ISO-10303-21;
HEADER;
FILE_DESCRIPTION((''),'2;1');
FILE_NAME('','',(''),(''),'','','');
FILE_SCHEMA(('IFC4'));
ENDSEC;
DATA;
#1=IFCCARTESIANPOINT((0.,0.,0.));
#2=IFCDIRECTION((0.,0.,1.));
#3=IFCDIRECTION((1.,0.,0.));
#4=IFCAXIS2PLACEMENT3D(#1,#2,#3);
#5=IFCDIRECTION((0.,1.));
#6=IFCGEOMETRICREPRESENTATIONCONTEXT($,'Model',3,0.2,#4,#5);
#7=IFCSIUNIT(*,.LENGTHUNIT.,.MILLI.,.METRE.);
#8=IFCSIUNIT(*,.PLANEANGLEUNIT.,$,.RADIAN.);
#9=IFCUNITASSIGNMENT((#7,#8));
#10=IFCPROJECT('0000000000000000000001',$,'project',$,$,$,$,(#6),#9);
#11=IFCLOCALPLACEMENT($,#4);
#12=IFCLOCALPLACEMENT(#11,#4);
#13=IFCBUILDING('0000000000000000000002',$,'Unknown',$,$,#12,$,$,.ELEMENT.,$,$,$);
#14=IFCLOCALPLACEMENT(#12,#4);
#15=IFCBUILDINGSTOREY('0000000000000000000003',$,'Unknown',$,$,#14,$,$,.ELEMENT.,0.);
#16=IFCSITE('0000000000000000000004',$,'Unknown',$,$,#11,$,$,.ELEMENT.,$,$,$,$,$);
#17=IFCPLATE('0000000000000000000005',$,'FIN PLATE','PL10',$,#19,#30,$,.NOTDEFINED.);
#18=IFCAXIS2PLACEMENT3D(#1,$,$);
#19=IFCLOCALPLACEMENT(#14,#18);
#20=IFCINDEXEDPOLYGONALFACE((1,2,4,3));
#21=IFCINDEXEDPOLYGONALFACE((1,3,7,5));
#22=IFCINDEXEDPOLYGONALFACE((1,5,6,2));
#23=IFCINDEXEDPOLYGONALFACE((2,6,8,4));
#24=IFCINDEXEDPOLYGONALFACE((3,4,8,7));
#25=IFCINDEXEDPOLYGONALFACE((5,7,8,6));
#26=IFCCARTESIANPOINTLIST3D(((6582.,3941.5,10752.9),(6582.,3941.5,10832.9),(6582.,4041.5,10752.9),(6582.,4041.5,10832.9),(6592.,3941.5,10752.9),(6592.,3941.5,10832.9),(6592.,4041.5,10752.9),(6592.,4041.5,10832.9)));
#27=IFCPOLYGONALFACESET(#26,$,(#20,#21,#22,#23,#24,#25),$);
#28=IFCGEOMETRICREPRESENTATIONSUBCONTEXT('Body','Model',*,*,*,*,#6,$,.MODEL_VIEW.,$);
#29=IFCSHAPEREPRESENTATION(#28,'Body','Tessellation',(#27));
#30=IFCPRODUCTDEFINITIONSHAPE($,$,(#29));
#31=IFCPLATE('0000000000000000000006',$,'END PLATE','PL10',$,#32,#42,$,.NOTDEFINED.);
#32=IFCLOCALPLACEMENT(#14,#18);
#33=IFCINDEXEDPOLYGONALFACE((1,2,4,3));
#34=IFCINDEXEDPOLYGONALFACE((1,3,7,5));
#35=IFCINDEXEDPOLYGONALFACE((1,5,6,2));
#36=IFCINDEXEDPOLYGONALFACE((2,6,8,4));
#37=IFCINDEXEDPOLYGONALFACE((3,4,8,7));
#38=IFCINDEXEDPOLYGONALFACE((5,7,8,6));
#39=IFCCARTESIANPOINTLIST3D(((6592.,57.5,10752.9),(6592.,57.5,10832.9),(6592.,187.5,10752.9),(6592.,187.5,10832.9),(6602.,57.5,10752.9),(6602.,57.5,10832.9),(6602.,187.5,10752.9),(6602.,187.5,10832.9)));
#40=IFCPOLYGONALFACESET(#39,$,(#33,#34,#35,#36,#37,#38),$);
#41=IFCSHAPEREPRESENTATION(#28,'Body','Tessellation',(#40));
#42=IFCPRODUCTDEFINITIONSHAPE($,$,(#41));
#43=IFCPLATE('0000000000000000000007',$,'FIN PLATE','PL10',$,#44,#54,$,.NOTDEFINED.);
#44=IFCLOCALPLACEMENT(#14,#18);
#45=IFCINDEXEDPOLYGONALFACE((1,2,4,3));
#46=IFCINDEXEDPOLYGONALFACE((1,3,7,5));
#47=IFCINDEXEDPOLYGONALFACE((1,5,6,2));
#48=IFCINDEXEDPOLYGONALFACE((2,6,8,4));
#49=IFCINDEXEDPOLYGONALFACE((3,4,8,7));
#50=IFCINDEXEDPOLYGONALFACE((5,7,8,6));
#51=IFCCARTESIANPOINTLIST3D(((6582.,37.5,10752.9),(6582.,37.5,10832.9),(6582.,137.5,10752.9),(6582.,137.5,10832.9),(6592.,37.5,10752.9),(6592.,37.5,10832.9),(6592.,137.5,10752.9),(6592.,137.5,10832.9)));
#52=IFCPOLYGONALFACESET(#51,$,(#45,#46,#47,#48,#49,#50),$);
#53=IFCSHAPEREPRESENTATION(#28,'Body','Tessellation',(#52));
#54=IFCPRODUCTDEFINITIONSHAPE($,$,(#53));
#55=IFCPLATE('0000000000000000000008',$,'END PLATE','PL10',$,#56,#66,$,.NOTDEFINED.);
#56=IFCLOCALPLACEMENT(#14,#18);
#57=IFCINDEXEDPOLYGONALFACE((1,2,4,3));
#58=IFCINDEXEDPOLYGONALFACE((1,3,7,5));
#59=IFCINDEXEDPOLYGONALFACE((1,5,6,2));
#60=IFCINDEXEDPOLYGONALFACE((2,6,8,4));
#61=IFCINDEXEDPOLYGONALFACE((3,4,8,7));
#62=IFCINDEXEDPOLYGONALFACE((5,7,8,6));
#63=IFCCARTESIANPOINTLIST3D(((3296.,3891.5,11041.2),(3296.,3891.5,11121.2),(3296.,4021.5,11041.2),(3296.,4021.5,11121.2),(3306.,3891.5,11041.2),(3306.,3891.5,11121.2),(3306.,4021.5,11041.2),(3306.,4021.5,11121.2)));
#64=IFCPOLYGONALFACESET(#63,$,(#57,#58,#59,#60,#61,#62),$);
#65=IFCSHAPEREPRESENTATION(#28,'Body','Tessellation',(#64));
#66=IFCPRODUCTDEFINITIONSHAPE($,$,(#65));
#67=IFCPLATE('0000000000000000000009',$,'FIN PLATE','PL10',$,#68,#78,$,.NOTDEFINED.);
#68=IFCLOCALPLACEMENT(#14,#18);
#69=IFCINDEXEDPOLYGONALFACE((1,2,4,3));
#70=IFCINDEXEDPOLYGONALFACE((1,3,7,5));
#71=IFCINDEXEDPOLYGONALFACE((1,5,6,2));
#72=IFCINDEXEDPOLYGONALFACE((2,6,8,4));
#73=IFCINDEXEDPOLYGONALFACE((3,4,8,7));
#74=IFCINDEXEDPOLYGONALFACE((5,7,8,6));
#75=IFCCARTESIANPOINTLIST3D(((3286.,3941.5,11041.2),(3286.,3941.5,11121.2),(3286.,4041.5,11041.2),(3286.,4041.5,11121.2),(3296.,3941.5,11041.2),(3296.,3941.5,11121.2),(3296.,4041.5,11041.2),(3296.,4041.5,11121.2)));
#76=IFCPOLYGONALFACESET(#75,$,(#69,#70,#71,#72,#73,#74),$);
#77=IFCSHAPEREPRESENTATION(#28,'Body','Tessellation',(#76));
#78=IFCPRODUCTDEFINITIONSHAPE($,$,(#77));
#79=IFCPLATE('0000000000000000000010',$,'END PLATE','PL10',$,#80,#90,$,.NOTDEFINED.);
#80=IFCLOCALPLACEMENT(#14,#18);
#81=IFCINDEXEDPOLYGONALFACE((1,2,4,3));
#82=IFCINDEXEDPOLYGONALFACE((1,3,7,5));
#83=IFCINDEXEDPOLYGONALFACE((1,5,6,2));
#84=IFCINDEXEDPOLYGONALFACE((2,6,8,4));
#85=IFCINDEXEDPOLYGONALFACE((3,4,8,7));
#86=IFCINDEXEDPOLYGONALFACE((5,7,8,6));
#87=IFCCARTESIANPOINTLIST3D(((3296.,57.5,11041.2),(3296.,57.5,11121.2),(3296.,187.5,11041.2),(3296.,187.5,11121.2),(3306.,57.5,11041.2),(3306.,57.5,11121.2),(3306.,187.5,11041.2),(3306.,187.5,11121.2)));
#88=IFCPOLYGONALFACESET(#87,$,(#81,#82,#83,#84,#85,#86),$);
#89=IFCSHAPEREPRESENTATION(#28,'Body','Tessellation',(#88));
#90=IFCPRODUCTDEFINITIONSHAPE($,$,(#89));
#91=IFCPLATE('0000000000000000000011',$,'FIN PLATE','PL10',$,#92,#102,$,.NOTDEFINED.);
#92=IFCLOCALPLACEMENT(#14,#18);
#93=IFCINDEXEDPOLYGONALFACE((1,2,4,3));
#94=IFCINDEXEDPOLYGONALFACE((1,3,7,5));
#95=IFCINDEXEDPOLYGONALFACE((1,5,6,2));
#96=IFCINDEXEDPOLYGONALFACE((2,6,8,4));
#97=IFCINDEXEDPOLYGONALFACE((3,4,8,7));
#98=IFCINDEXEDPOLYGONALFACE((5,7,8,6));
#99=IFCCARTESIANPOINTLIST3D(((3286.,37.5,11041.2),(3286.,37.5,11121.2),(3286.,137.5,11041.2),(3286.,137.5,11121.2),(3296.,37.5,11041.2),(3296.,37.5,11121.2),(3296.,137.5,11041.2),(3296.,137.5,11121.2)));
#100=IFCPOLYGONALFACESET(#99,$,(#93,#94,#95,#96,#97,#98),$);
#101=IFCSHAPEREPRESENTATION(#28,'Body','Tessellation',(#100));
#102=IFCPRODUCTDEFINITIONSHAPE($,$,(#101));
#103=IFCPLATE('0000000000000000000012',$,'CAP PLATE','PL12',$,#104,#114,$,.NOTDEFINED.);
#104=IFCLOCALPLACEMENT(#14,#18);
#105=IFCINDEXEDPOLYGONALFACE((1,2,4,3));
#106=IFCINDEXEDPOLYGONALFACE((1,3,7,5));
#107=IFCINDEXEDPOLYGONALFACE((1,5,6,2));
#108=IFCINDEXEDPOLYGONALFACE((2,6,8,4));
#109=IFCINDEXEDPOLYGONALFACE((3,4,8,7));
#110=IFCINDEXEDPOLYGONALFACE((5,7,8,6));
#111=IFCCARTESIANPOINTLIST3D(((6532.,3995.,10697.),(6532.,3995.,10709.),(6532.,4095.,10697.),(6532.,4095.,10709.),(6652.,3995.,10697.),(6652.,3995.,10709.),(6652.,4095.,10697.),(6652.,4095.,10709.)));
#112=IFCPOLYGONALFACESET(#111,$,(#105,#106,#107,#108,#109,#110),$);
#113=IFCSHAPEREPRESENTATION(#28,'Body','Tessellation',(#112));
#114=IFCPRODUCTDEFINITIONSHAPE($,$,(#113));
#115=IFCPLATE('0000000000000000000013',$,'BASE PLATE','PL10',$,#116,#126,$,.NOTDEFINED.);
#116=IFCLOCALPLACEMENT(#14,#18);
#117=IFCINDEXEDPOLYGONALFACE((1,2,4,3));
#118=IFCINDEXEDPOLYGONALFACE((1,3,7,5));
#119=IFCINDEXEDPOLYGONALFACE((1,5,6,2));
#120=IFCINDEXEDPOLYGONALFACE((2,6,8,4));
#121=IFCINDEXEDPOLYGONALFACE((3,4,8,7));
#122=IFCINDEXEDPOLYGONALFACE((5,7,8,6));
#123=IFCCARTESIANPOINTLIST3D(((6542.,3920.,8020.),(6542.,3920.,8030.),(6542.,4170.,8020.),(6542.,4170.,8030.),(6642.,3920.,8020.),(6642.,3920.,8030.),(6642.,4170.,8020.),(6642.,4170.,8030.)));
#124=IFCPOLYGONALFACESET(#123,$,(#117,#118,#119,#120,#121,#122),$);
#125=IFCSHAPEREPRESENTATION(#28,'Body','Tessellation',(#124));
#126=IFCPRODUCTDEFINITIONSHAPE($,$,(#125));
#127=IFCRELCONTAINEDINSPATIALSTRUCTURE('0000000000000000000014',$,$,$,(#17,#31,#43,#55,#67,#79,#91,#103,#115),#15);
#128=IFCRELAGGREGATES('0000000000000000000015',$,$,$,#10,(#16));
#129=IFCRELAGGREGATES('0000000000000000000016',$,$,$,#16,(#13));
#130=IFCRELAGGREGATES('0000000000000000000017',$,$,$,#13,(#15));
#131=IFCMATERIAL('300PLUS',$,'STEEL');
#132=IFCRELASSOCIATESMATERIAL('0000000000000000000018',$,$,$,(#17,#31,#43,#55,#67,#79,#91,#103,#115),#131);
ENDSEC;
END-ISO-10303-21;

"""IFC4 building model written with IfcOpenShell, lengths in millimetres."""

from ifc_helpers import new_model, si_unit, direction, frame, origin_with_axes, place, context, subcontext, project, spatial, line, indexed_curve, outline, extrude, material, element, save


model = new_model("IFC4")

# Units and contexts
model_context = context("Model", 3, precision=0.2, world=origin_with_axes(), true_north=direction((0.0, 1.0)))
body_context = subcontext(model_context, "Body", "Model", "MODEL_VIEW")
ifc_project = project(units=[si_unit("LENGTHUNIT", "METRE", prefix="MILLI"), si_unit("PLANEANGLEUNIT", "RADIAN")], contexts=[model_context])

# Site, building, storey
site_placement = place(None, origin_with_axes())
site = spatial("IfcSite", under=ifc_project, at=site_placement, Name="Unknown", CompositionType="ELEMENT")
building_placement = place(site_placement, origin_with_axes())
building = spatial("IfcBuilding", under=site, at=building_placement, Name="Unknown", CompositionType="ELEMENT")
storey_placement = place(building_placement, origin_with_axes())
storey = spatial("IfcBuildingStorey", under=building, at=storey_placement, Name="Unknown", CompositionType="ELEMENT", Elevation=0.0)

# Plates
ifc_material_1 = material(Name="300PLUS", Category="STEEL")
plate_1_placement = place(storey_placement, frame((6587.0, 4041.5, 10752.9), z_axis=(-1.0, 0.0, 0.0), x_axis=(0.0, -1.0, 0.0)))
element("IfcPlate", 1, at=plate_1_placement, inside=storey, material=ifc_material_1, Name="FIN PLATE", Description="PL10", PredefinedType="NOTDEFINED", context=body_context, shape_type="SolidModel", body=[
    extrude(outline(indexed_curve([(0.0, 0.0), (100.0, 0.0), (100.0, 80.0), (0.0, 80.0)], segments=[line(1, 2, 3, 4, 1)])), frame((0.0, 0.0, 5.0), z_axis=(0.0, 0.0, 1.0), x_axis=(1.0, 0.0, 0.0)), (0.0, 0.0, -1.0), 10.0),
])
plate_2_placement = place(storey_placement, frame((6597.0, 187.5, 10832.9), z_axis=(1.0, 0.0, 0.0), x_axis=(0.0, -1.0, 0.0)))
element("IfcPlate", 2, at=plate_2_placement, inside=storey, material=ifc_material_1, Name="END PLATE", Description="PL10", PredefinedType="NOTDEFINED", context=body_context, shape_type="SolidModel", body=[
    extrude(outline(indexed_curve([(0.0, 0.0), (130.0, 0.0), (130.0, 80.0), (0.0, 80.0)], segments=[line(1, 2, 3, 4, 1)])), frame((0.0, 0.0, 5.0), z_axis=(0.0, 0.0, 1.0), x_axis=(1.0, 0.0, 0.0)), (0.0, 0.0, -1.0), 10.0),
])
plate_3_placement = place(storey_placement, frame((6587.0, 37.5, 10832.9), z_axis=(-1.0, 0.0, 0.0), x_axis=(0.0, 1.0, 0.0)))
element("IfcPlate", 3, at=plate_3_placement, inside=storey, material=ifc_material_1, Name="FIN PLATE", Description="PL10", PredefinedType="NOTDEFINED", context=body_context, shape_type="SolidModel", body=[
    extrude(outline(indexed_curve([(0.0, 0.0), (100.0, 0.0), (100.0, 80.0), (0.0, 80.0)], segments=[line(1, 2, 3, 4, 1)])), frame((0.0, 0.0, 5.0), z_axis=(0.0, 0.0, 1.0), x_axis=(1.0, 0.0, 0.0)), (0.0, 0.0, -1.0), 10.0),
])
plate_4_placement = place(storey_placement, frame((3301.0, 3891.5, 11041.2), z_axis=(1.0, 0.0, 0.0), x_axis=(0.0, 1.0, 0.0)))
element("IfcPlate", 4, at=plate_4_placement, inside=storey, material=ifc_material_1, Name="END PLATE", Description="PL10", PredefinedType="NOTDEFINED", context=body_context, shape_type="SolidModel", body=[
    extrude(outline(indexed_curve([(0.0, 0.0), (130.0, 0.0), (130.0, 80.0), (0.0, 80.0)], segments=[line(1, 2, 3, 4, 1)])), frame((0.0, 0.0, 5.0), z_axis=(0.0, 0.0, 1.0), x_axis=(1.0, 0.0, 0.0)), (0.0, 0.0, -1.0), 10.0),
])
plate_5_placement = place(storey_placement, frame((3291.0, 4041.5, 11041.2), z_axis=(-1.0, 0.0, 0.0), x_axis=(0.0, -1.0, 0.0)))
element("IfcPlate", 5, at=plate_5_placement, inside=storey, material=ifc_material_1, Name="FIN PLATE", Description="PL10", PredefinedType="NOTDEFINED", context=body_context, shape_type="SolidModel", body=[
    extrude(outline(indexed_curve([(0.0, 0.0), (100.0, 0.0), (100.0, 80.0), (0.0, 80.0)], segments=[line(1, 2, 3, 4, 1)])), frame((0.0, 0.0, 5.0), z_axis=(0.0, 0.0, 1.0), x_axis=(1.0, 0.0, 0.0)), (0.0, 0.0, -1.0), 10.0),
])
plate_6_placement = place(storey_placement, frame((3301.0, 187.5, 11121.2), z_axis=(1.0, 0.0, 0.0), x_axis=(0.0, -1.0, 0.0)))
element("IfcPlate", 6, at=plate_6_placement, inside=storey, material=ifc_material_1, Name="END PLATE", Description="PL10", PredefinedType="NOTDEFINED", context=body_context, shape_type="SolidModel", body=[
    extrude(outline(indexed_curve([(0.0, 0.0), (130.0, 0.0), (130.0, 80.0), (0.0, 80.0)], segments=[line(1, 2, 3, 4, 1)])), frame((0.0, 0.0, 5.0), z_axis=(0.0, 0.0, 1.0), x_axis=(1.0, 0.0, 0.0)), (0.0, 0.0, -1.0), 10.0),
])
plate_7_placement = place(storey_placement, frame((3291.0, 37.5, 11121.2), z_axis=(-1.0, 0.0, 0.0), x_axis=(0.0, 1.0, 0.0)))
element("IfcPlate", 7, at=plate_7_placement, inside=storey, material=ifc_material_1, Name="FIN PLATE", Description="PL10", PredefinedType="NOTDEFINED", context=body_context, shape_type="SolidModel", body=[
    extrude(outline(indexed_curve([(0.0, 0.0), (100.0, 0.0), (100.0, 80.0), (0.0, 80.0)], segments=[line(1, 2, 3, 4, 1)])), frame((0.0, 0.0, 5.0), z_axis=(0.0, 0.0, 1.0), x_axis=(1.0, 0.0, 0.0)), (0.0, 0.0, -1.0), 10.0),
])
plate_8_placement = place(storey_placement, frame((6532.0, 3995.0, 10703.0), z_axis=(0.0, 0.0, 1.0), x_axis=(1.0, 0.0, 0.0)))
element("IfcPlate", 8, at=plate_8_placement, inside=storey, material=ifc_material_1, Name="CAP PLATE", Description="PL12", PredefinedType="NOTDEFINED", context=body_context, shape_type="SolidModel", body=[
    extrude(outline(indexed_curve([(0.0, 0.0), (120.0, 0.0), (120.0, 100.0), (0.0, 100.0)], segments=[line(1, 2, 3, 4, 1)])), frame((0.0, 0.0, 6.0), z_axis=(0.0, 0.0, 1.0), x_axis=(1.0, 0.0, 0.0)), (0.0, 0.0, -1.0), 12.0),
])
plate_9_placement = place(storey_placement, frame((6542.0, 3920.0, 8025.0), z_axis=(0.0, 0.0, 1.0), x_axis=(1.0, 0.0, 0.0)))
element("IfcPlate", 9, at=plate_9_placement, inside=storey, material=ifc_material_1, Name="BASE PLATE", Description="PL10", PredefinedType="NOTDEFINED", context=body_context, shape_type="SolidModel", body=[
    extrude(outline(indexed_curve([(0.0, 0.0), (100.0, 0.0), (100.0, 250.0), (0.0, 250.0)], segments=[line(1, 2, 3, 4, 1)])), frame((0.0, 0.0, 5.0), z_axis=(0.0, 0.0, 1.0), x_axis=(1.0, 0.0, 0.0)), (0.0, 0.0, -1.0), 10.0),
])

save(model, "model.ifc")
